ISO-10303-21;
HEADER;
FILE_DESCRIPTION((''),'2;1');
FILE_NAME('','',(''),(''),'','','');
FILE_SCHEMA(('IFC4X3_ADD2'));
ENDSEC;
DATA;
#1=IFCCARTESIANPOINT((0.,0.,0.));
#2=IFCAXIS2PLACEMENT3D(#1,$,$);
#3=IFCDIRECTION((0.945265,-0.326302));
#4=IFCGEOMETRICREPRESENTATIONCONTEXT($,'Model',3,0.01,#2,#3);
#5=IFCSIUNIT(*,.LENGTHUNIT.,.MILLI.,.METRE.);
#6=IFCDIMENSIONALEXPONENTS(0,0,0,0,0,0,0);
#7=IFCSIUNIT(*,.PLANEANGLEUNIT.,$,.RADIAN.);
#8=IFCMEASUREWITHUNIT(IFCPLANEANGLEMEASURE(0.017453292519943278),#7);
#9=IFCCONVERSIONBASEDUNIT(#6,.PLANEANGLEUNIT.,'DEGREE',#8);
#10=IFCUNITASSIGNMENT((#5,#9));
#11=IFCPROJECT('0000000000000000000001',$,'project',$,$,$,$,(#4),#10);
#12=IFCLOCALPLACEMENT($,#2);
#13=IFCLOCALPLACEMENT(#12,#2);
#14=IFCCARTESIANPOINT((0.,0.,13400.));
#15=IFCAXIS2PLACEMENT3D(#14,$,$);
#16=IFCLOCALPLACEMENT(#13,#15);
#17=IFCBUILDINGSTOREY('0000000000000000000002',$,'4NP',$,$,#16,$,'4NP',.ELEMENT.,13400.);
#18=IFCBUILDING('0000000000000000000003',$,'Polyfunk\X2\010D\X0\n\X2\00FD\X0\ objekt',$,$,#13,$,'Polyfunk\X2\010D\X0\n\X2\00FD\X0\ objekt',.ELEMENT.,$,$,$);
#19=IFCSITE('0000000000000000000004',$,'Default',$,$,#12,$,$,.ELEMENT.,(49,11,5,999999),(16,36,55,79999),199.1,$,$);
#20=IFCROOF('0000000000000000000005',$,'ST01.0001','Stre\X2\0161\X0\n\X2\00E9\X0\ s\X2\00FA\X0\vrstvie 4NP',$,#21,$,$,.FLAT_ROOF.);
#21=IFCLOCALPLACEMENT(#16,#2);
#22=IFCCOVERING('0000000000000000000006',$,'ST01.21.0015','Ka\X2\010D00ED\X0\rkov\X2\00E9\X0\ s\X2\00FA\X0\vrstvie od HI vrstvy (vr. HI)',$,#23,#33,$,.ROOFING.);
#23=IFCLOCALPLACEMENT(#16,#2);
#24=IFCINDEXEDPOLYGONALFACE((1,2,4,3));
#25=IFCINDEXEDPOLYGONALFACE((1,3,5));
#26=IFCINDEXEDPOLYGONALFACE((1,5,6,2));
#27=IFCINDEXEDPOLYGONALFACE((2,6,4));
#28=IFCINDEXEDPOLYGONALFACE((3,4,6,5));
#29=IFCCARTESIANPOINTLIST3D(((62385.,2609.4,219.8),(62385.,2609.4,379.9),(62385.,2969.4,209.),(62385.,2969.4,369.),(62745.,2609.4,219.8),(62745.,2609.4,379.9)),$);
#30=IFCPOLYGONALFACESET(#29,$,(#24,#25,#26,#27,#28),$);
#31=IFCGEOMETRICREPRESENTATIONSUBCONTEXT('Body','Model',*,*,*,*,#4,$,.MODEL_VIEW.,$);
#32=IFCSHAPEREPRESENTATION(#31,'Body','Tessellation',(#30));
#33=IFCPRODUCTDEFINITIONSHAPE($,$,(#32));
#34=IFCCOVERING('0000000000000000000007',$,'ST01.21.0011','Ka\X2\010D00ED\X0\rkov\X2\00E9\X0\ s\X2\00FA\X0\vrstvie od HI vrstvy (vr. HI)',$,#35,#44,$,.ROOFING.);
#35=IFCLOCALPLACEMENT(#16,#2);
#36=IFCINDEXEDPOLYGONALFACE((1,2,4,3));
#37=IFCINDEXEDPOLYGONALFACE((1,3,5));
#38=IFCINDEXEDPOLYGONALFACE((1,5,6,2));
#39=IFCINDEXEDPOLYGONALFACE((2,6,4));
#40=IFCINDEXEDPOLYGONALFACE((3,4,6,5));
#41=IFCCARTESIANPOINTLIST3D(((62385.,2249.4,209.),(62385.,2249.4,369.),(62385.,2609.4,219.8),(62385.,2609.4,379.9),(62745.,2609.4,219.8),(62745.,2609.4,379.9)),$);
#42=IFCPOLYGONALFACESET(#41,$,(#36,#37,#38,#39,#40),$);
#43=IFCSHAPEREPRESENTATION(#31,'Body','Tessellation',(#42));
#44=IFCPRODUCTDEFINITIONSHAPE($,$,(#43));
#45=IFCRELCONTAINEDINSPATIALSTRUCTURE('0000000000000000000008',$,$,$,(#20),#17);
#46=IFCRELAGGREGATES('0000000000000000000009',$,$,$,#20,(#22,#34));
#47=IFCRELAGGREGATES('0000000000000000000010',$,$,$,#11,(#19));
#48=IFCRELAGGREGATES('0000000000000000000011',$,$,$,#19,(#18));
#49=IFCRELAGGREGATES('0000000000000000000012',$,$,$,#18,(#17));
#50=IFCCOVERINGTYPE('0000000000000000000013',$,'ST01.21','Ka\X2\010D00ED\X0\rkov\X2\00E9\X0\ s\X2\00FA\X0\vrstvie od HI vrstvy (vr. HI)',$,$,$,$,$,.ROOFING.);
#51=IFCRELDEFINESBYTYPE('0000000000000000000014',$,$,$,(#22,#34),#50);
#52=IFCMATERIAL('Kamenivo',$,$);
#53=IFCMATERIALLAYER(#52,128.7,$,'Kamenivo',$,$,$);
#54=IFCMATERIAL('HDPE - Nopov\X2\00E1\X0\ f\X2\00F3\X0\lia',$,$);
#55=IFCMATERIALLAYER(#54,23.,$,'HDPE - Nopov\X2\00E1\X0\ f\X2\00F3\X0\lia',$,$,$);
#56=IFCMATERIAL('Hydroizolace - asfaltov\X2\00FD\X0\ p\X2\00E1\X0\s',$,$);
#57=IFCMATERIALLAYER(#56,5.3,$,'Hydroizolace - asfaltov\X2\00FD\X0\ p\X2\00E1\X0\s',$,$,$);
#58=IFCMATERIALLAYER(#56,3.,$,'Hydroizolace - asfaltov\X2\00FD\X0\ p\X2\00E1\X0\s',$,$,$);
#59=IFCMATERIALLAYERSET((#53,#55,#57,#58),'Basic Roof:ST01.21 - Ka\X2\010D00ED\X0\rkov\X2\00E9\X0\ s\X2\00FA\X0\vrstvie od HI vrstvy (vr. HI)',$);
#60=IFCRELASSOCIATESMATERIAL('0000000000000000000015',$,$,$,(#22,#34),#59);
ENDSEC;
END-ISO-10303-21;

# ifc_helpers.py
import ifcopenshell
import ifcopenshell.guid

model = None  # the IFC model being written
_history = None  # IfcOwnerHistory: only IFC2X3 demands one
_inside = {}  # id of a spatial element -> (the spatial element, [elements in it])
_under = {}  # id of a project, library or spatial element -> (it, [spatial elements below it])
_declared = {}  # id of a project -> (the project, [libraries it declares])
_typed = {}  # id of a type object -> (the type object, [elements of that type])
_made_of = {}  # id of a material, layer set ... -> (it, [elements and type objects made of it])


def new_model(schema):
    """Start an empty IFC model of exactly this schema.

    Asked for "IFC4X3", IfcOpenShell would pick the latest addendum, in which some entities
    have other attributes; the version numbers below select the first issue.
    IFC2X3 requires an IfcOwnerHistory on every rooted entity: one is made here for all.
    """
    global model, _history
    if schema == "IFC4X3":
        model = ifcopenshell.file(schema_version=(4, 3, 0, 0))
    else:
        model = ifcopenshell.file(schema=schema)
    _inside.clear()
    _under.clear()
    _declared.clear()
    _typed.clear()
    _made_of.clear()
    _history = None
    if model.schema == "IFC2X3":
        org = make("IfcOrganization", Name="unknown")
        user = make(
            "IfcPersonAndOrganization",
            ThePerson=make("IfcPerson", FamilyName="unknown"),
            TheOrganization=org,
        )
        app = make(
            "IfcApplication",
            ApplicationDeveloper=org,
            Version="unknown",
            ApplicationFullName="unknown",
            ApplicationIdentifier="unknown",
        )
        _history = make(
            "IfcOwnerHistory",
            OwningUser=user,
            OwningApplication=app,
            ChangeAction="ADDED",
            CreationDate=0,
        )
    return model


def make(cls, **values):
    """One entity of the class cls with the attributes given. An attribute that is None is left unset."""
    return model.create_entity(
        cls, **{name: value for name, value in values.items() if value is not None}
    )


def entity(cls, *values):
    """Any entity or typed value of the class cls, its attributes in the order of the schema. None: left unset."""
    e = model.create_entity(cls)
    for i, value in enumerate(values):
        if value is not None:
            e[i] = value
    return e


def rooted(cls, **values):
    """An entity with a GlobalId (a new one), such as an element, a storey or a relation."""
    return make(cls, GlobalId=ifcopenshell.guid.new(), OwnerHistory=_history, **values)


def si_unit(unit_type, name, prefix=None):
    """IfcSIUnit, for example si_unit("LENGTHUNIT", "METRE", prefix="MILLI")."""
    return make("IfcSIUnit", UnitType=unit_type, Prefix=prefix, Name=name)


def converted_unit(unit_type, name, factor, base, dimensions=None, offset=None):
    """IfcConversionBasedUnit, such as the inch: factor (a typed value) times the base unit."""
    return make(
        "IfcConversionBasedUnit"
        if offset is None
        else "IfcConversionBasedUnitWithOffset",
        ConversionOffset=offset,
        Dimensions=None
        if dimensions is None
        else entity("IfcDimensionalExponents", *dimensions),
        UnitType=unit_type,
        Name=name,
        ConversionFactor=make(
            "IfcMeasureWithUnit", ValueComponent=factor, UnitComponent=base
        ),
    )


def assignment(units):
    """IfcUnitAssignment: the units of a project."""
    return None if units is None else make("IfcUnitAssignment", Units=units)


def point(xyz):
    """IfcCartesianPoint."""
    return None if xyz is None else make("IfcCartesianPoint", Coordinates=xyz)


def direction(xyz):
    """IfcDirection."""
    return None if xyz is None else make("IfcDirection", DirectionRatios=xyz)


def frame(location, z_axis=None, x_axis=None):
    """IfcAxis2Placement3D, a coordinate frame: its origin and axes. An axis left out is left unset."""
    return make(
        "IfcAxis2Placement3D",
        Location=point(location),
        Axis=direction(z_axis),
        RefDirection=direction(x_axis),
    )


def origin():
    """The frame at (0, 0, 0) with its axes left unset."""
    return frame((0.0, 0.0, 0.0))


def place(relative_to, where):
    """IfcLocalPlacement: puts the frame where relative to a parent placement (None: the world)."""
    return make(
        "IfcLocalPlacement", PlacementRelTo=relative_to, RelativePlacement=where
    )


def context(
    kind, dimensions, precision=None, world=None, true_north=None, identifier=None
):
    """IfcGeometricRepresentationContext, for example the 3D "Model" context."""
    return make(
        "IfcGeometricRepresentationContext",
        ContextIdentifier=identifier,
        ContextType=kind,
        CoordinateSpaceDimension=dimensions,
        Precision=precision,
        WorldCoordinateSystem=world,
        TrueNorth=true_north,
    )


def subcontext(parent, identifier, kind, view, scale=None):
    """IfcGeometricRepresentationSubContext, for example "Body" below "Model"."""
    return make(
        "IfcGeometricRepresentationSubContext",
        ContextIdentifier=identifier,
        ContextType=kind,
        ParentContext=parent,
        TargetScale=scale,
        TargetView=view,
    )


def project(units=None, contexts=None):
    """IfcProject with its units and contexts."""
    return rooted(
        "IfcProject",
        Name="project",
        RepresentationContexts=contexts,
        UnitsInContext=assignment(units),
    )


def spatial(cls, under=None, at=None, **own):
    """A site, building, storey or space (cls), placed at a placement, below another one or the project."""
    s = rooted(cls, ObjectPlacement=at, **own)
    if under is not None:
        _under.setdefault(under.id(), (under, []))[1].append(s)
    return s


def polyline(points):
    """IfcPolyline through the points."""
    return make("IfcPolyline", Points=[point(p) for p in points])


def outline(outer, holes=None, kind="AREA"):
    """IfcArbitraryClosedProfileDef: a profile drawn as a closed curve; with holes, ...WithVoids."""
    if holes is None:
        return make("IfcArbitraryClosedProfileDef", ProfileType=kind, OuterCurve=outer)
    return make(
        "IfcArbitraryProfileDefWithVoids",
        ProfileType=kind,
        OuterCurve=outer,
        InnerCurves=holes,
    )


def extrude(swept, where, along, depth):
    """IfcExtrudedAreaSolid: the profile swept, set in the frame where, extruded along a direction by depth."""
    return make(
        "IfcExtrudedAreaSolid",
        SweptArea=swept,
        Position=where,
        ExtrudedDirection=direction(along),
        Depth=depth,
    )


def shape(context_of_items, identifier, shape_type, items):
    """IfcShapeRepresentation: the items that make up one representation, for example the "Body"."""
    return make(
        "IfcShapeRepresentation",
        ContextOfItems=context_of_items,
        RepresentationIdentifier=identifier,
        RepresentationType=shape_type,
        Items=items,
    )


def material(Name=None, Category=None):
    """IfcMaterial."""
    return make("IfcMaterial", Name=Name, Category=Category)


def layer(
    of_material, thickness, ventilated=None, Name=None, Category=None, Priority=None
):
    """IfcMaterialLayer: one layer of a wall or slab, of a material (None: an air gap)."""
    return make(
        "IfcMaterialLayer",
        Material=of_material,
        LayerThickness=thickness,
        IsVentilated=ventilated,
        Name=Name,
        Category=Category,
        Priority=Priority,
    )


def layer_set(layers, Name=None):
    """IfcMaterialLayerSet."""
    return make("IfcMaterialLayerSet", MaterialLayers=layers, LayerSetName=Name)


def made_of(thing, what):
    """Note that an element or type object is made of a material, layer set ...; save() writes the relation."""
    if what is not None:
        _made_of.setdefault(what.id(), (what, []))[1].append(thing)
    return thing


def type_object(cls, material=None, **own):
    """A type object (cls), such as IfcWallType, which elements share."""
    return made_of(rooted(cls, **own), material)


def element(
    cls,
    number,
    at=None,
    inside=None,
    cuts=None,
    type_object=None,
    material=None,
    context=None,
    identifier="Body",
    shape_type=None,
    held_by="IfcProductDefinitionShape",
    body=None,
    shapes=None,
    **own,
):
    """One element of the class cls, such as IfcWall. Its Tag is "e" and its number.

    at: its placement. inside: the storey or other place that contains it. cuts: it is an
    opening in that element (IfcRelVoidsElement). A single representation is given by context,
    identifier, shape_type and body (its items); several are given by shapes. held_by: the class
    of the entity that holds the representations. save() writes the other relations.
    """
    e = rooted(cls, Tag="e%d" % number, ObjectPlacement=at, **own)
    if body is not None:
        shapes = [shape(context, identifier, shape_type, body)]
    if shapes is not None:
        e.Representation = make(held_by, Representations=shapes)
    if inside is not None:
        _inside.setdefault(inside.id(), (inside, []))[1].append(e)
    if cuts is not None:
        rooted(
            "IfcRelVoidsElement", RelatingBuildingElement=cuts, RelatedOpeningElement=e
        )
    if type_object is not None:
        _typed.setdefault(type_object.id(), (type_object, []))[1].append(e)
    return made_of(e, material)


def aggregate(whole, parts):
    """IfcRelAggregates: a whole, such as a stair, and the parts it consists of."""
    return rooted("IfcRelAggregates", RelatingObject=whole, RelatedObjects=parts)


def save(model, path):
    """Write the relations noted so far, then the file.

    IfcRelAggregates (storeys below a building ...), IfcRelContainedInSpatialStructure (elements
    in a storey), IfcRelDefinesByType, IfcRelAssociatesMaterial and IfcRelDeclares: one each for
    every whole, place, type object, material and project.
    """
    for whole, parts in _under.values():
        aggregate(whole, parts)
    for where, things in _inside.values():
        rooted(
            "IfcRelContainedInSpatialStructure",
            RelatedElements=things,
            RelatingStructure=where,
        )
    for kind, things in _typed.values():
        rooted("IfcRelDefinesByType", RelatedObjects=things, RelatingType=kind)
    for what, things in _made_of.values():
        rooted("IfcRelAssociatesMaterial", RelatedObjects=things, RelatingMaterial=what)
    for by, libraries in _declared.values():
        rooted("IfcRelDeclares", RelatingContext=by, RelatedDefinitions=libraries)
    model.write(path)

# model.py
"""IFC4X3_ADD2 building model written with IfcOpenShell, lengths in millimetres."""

from ifc_helpers import new_model, entity, si_unit, converted_unit, direction, frame, origin, place, context, subcontext, project, spatial, polyline, outline, extrude, material, layer, layer_set, type_object, element, aggregate, save


model = new_model("IFC4X3_ADD2")

# Units and contexts
model_context = context("Model", 3, precision=0.01, world=origin(), true_north=direction((0.945265, -0.326302)))
body_context = subcontext(model_context, "Body", "Model", "MODEL_VIEW")
ifc_project = project(units=[si_unit("LENGTHUNIT", "METRE", prefix="MILLI"), converted_unit("PLANEANGLEUNIT", "DEGREE", entity("IfcPlaneAngleMeasure", 0.017453292519943278), si_unit("PLANEANGLEUNIT", "RADIAN"), dimensions=[0, 0, 0, 0, 0, 0, 0])], contexts=[model_context])

# Site, building, storey
site_placement = place(None, origin())
site = spatial("IfcSite", under=ifc_project, at=site_placement, Name="Default", CompositionType="ELEMENT", RefLatitude=(49, 11, 5, 999999), RefLongitude=(16, 36, 55, 79999), RefElevation=199.1)
building_placement = place(site_placement, origin())
building = spatial("IfcBuilding", under=site, at=building_placement, Name="Polyfunkčný objekt", LongName="Polyfunkčný objekt", CompositionType="ELEMENT")
storey_placement = place(building_placement, frame((0.0, 0.0, 13400.0)))
storey = spatial("IfcBuildingStorey", under=building, at=storey_placement, Name="4NP", LongName="4NP", CompositionType="ELEMENT", Elevation=13400.0)

# Roof, coverings
roof = element("IfcRoof", 1, inside=storey, Name="ST01.0001", Description="Strešné súvrstvie 4NP", PredefinedType="FLAT_ROOF")
ifc_material_1 = material(Name="Kamenivo")
ifc_layer_1 = layer(ifc_material_1, 128.7, Name="Kamenivo")
ifc_material_2 = material(Name="HDPE - Nopová fólia")
ifc_layer_2 = layer(ifc_material_2, 23.0, Name="HDPE - Nopová fólia")
ifc_material_3 = material(Name="Hydroizolace - asfaltový pás")
ifc_layer_3 = layer(ifc_material_3, 5.3, Name="Hydroizolace - asfaltový pás")
ifc_layer_4 = layer(ifc_material_3, 3.0, Name="Hydroizolace - asfaltový pás")
ifc_layer_set_1 = layer_set([ifc_layer_1, ifc_layer_2, ifc_layer_3, ifc_layer_4], Name="Basic Roof:ST01.21 - Kačírkové súvrstvie od HI vrstvy (vr. HI)")
covering_type = type_object("IfcCoveringType", Name="ST01.21", Description="Kačírkové súvrstvie od HI vrstvy (vr. HI)", PredefinedType="ROOFING")
placement_1 = place(storey_placement, frame((62385.0, 2609.4, 209.0)))
covering_1_placement = place(placement_1, origin())
covering_1 = element("IfcCovering", 2, at=covering_1_placement, type_object=covering_type, material=ifc_layer_set_1, Name="ST01.21.0015", Description="Kačírkové súvrstvie od HI vrstvy (vr. HI)", PredefinedType="ROOFING", context=body_context, shape_type="SweptSolid", body=[
    extrude(outline(polyline([(180.0, -180.1), (-180.0, 180.1), (-180.0, -180.1), (180.0, -180.1)])), frame((180.0, 180.0, 5.4), z_axis=(0.0, 0.030015, 0.999549), x_axis=(1.0, 0.0, 0.0)), (0.0, -0.030015, 0.999549), 160.1),
])
placement_2 = place(storey_placement, frame((62385.0, 2249.4, 209.0)))
covering_2_placement = place(placement_2, origin())
covering_2 = element("IfcCovering", 3, at=covering_2_placement, type_object=covering_type, material=ifc_layer_set_1, Name="ST01.21.0011", Description="Kačírkové súvrstvie od HI vrstvy (vr. HI)", PredefinedType="ROOFING", context=body_context, shape_type="SweptSolid", body=[
    extrude(outline(polyline([(-180.0, 180.1), (-180.0, -180.1), (180.0, 180.1), (-180.0, 180.1)])), frame((180.0, 180.0, 5.4), z_axis=(0.0, -0.030015, 0.999549), x_axis=(1.0, 0.0, 0.0)), (0.0, 0.030015, 0.999549), 160.1),
])
aggregate(roof, [covering_1, covering_2])

save(model, "model.ifc")
